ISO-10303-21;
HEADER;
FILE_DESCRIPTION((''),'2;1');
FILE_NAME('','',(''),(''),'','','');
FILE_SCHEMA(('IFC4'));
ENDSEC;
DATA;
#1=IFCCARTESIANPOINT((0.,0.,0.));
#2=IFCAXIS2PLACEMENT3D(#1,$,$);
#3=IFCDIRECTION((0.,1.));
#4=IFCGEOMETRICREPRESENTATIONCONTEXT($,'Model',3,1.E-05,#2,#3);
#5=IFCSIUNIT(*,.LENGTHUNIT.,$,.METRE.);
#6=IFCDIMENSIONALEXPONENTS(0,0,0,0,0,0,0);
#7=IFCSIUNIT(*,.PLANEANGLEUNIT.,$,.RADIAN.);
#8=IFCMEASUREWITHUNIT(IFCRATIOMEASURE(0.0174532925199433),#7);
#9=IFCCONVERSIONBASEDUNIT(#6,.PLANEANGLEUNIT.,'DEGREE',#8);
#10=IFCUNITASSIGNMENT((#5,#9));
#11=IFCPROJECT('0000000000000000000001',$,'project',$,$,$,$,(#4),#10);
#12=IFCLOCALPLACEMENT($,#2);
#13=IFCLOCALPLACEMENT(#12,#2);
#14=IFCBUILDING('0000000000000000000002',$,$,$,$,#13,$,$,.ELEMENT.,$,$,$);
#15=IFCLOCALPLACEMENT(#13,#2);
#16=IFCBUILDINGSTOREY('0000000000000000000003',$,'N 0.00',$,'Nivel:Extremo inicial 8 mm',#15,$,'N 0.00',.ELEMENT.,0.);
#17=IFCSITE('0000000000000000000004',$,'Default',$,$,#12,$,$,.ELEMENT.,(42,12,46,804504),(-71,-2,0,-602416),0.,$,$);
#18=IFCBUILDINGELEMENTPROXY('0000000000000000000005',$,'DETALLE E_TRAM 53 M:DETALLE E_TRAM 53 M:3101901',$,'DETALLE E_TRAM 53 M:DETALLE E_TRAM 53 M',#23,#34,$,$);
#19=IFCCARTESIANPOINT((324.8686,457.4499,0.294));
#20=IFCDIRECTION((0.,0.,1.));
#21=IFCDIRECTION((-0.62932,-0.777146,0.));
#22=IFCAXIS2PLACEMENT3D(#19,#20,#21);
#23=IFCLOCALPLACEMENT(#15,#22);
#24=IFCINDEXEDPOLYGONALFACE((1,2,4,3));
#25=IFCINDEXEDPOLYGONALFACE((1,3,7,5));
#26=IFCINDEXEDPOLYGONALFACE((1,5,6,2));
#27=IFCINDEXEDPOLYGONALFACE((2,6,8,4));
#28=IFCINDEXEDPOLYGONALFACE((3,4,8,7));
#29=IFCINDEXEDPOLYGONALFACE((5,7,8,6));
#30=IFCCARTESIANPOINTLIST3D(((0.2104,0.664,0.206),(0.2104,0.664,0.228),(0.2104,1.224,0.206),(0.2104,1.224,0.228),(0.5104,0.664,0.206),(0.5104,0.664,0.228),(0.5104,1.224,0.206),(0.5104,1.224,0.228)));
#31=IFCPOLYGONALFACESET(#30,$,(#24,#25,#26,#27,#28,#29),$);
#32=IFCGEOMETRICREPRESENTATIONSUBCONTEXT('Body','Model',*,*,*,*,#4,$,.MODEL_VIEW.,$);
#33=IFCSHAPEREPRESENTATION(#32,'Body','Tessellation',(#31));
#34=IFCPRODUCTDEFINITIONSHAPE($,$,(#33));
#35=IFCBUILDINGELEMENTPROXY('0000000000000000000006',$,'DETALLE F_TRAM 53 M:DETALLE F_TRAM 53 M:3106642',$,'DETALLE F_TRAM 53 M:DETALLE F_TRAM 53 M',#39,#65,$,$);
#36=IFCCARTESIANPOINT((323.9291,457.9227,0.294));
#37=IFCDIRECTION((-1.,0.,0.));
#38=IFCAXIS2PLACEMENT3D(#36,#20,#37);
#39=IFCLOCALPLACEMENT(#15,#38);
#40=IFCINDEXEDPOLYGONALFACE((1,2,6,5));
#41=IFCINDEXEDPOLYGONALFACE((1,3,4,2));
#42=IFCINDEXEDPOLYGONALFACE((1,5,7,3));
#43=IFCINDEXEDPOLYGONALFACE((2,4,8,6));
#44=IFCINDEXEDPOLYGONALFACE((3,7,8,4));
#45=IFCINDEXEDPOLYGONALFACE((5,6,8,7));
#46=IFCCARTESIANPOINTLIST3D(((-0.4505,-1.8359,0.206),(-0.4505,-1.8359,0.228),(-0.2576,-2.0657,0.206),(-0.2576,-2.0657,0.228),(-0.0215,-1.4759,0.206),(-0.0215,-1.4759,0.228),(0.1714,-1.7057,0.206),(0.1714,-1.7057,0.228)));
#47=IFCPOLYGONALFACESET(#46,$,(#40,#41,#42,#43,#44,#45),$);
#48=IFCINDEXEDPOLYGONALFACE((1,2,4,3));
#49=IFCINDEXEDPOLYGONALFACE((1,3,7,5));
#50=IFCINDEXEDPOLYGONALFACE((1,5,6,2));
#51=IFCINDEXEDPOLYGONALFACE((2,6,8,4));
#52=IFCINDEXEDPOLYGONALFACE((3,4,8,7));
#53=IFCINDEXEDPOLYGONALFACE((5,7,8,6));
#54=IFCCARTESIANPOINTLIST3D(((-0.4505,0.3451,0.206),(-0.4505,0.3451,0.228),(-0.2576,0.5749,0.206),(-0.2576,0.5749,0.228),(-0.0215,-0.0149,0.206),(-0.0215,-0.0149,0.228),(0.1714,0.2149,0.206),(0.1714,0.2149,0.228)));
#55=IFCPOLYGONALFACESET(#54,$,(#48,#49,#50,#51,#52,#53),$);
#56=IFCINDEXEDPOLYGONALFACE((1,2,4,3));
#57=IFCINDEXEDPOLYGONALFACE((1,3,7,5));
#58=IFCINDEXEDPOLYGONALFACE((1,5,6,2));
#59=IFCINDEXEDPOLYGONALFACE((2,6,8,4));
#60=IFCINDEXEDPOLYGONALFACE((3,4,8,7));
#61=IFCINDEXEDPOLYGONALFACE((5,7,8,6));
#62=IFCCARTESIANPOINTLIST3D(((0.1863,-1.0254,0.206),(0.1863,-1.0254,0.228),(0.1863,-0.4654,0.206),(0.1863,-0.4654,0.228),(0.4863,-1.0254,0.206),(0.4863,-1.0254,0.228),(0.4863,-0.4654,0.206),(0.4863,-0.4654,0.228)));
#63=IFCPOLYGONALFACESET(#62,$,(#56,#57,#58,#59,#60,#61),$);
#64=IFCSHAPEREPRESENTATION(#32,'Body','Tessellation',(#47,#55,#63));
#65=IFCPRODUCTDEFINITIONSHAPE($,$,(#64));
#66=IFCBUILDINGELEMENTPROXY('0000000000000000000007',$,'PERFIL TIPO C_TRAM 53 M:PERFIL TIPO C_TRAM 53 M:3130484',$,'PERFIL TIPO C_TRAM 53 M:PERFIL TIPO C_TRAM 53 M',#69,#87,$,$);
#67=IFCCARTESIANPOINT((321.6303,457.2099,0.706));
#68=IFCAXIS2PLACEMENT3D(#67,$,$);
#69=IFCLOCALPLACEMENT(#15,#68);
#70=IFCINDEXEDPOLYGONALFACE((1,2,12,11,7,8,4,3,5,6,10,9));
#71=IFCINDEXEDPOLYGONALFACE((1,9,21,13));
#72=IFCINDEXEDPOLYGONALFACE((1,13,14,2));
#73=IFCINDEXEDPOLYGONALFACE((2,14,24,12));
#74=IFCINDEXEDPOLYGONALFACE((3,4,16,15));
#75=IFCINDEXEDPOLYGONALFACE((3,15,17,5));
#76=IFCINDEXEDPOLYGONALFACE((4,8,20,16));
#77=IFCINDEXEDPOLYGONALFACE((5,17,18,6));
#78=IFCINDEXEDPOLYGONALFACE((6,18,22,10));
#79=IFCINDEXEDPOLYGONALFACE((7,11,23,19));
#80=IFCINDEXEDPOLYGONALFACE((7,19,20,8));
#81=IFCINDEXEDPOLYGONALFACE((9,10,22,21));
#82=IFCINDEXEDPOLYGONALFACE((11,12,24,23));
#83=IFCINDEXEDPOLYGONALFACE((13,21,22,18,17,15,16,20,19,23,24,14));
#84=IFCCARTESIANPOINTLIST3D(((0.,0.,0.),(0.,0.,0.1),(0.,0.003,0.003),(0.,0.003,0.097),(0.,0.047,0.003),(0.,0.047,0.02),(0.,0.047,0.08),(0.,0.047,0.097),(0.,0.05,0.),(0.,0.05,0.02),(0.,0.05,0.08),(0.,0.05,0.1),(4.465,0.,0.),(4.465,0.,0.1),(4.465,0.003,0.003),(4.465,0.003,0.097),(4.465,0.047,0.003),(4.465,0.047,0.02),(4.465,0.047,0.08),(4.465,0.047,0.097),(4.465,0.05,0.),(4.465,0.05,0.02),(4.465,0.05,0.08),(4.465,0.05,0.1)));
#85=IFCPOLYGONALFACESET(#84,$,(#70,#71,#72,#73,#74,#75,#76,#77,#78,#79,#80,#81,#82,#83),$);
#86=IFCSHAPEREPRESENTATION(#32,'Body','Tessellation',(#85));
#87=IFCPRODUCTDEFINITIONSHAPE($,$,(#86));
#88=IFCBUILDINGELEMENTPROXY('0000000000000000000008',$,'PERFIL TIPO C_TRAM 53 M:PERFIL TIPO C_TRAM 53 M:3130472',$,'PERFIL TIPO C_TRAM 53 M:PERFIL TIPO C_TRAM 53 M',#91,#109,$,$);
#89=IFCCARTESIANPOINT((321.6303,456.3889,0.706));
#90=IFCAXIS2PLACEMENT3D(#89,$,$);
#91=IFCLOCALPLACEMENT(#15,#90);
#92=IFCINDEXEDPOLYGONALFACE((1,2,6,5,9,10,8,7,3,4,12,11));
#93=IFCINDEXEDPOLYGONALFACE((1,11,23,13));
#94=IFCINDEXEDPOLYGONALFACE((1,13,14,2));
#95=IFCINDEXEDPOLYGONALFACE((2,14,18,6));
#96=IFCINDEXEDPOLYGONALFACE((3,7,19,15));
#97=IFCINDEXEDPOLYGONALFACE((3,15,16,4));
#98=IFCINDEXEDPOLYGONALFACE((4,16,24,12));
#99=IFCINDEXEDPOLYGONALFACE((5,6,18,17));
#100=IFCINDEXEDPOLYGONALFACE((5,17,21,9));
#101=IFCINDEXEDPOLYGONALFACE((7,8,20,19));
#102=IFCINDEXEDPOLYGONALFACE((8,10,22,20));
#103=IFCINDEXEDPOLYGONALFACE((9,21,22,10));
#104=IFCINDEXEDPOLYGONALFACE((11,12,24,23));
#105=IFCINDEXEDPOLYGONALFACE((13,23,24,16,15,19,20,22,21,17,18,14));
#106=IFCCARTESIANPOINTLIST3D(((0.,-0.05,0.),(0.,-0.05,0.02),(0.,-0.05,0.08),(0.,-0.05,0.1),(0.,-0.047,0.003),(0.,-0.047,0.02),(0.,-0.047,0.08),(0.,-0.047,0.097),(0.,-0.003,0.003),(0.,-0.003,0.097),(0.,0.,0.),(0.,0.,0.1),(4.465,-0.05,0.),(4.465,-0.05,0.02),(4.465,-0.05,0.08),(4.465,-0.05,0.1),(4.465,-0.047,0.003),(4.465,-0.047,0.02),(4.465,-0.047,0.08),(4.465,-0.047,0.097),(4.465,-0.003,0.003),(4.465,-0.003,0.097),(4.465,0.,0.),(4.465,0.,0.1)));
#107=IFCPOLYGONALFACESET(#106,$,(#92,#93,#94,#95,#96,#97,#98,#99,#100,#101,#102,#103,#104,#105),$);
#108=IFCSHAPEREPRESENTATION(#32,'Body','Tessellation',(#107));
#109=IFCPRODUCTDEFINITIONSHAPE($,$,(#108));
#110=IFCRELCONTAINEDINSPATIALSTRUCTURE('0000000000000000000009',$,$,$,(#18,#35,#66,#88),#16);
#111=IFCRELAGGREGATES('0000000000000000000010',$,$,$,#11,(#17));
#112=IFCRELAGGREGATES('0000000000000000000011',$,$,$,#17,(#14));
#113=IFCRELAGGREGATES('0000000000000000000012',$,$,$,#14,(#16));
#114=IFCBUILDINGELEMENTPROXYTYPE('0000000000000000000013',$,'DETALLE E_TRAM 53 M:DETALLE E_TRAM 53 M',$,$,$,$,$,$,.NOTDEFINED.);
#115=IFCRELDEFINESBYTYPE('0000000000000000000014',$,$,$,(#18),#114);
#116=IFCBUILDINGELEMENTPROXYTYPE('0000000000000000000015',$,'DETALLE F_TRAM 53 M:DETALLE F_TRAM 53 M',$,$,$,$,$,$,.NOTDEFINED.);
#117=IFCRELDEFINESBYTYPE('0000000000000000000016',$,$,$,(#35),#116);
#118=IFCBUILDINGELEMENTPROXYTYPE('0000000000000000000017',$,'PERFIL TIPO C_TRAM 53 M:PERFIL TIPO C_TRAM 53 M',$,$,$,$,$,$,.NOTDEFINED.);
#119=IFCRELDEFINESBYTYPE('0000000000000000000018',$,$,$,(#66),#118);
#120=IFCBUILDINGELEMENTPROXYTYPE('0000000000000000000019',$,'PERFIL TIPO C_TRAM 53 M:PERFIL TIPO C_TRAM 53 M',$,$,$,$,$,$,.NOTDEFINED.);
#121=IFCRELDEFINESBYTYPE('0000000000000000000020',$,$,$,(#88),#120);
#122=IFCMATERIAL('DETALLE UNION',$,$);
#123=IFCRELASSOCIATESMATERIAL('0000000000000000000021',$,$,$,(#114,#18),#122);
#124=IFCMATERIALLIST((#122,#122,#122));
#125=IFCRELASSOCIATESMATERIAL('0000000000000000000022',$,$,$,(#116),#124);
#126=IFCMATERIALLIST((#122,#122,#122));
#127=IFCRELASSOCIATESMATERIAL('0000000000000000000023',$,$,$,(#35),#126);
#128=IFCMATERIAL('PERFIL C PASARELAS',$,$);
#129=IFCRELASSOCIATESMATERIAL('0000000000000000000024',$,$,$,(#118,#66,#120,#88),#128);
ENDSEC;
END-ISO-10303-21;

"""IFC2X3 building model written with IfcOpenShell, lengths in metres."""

from ifc_helpers import new_model, entity, si_unit, converted_unit, direction, frame, frame_2d, origin, place, context, subcontext, project, spatial, polyline, rectangle, outline, extrude, source, transform, mapped, material, material_list, type_object, type_shapes, element, save


model = new_model("IFC2X3")

# Units and contexts
model_context = context("Model", 3, precision=1e-05, world=origin(), true_north=direction((0.0, 1.0)))
body_context = subcontext(model_context, "Body", "Model", "MODEL_VIEW")
ifc_project = project(units=[si_unit("LENGTHUNIT", "METRE"), converted_unit("PLANEANGLEUNIT", "DEGREE", entity("IfcRatioMeasure", 0.0174532925199433), si_unit("PLANEANGLEUNIT", "RADIAN"), dimensions=[0, 0, 0, 0, 0, 0, 0])], contexts=[model_context])

# Site, building, storey
site_placement = place(None, origin())
site = spatial("IfcSite", under=ifc_project, at=site_placement, Name="Default", CompositionType="ELEMENT", RefLatitude=(42, 12, 46, 804504), RefLongitude=(-71, -2, 0, -602416), RefElevation=0.0)
building_placement = place(site_placement, origin())
building = spatial("IfcBuilding", under=site, at=building_placement, CompositionType="ELEMENT")
storey_placement = place(building_placement, origin())
storey = spatial("IfcBuildingStorey", under=building, at=storey_placement, Name="N 0.00", ObjectType="Nivel:Extremo inicial 8 mm", LongName="N 0.00", CompositionType="ELEMENT", Elevation=0.0)

# Building element proxies
ifc_material_1 = material(Name="DETALLE UNION")
building_element_proxy_type_1 = type_object("IfcBuildingElementProxyType", Name="DETALLE E_TRAM 53 M:DETALLE E_TRAM 53 M", PredefinedType="NOTDEFINED", material=ifc_material_1)
shared_shape_1 = source(origin(), body_context, "Body", "SweptSolid", [
    extrude(rectangle(XDim=0.56, YDim=0.3, at=frame_2d((0.0, 0.0), x_axis=(1.0, 0.0))), frame((0.3604, 0.944, 0.206), z_axis=(0.0, 0.0, 1.0), x_axis=(0.0, 1.0, 0.0)), (0.0, 0.0, 1.0), 0.022),
])
type_shapes(building_element_proxy_type_1, [shared_shape_1])
proxy_1_placement = place(storey_placement, frame((324.8686, 457.4499, 0.294), z_axis=(0.0, 0.0, 1.0), x_axis=(-0.62932, -0.777146, 0.0)))
element("IfcBuildingElementProxy", 1, at=proxy_1_placement, inside=storey, type_object=building_element_proxy_type_1, material=ifc_material_1, Name="DETALLE E_TRAM 53 M:DETALLE E_TRAM 53 M:3101901", ObjectType="DETALLE E_TRAM 53 M:DETALLE E_TRAM 53 M", context=body_context, shape_type="MappedRepresentation", body=[
    mapped(shared_shape_1, transform((0.0, 0.0, 0.0), scale=1.0)),
])
ifc_material_list_1 = material_list([ifc_material_1, ifc_material_1, ifc_material_1])
ifc_material_list_2 = material_list([ifc_material_1, ifc_material_1, ifc_material_1])
building_element_proxy_type_2 = type_object("IfcBuildingElementProxyType", Name="DETALLE F_TRAM 53 M:DETALLE F_TRAM 53 M", PredefinedType="NOTDEFINED", material=ifc_material_list_2)
shared_shape_2 = source(origin(), body_context, "Body", "SweptSolid", [
    extrude(rectangle(XDim=0.56, YDim=0.3, at=frame_2d((0.0, 0.0), x_axis=(1.0, 0.0))), frame((-0.1396, -1.7708, 0.206), z_axis=(0.0, 0.0, 1.0), x_axis=(0.766044, 0.642788, 0.0)), (0.0, 0.0, 1.0), 0.022),
    extrude(rectangle(XDim=0.3, YDim=0.56, at=frame_2d((0.0, 0.0), x_axis=(1.0, 0.0))), frame((-0.1396, 0.28, 0.206), z_axis=(0.0, 0.0, 1.0), x_axis=(-0.642788, -0.766044, 0.0)), (0.0, 0.0, 1.0), 0.022),
    extrude(rectangle(XDim=0.3, YDim=0.56, at=frame_2d((0.0, 0.0), x_axis=(1.0, 0.0))), frame((0.3363, -0.7454, 0.206), z_axis=(0.0, 0.0, 1.0), x_axis=(-1.0, 0.0, 0.0)), (0.0, 0.0, 1.0), 0.022),
])
type_shapes(building_element_proxy_type_2, [shared_shape_2])
proxy_2_placement = place(storey_placement, frame((323.9291, 457.9227, 0.294), z_axis=(0.0, 0.0, 1.0), x_axis=(-1.0, 0.0, 0.0)))
element("IfcBuildingElementProxy", 2, at=proxy_2_placement, inside=storey, type_object=building_element_proxy_type_2, material=ifc_material_list_1, Name="DETALLE F_TRAM 53 M:DETALLE F_TRAM 53 M:3106642", ObjectType="DETALLE F_TRAM 53 M:DETALLE F_TRAM 53 M", context=body_context, shape_type="MappedRepresentation", body=[
    mapped(shared_shape_2, transform((0.0, 0.0, 0.0), scale=1.0)),
])
ifc_material_2 = material(Name="PERFIL C PASARELAS")
building_element_proxy_type_3 = type_object("IfcBuildingElementProxyType", Name="PERFIL TIPO C_TRAM 53 M:PERFIL TIPO C_TRAM 53 M", PredefinedType="NOTDEFINED", material=ifc_material_2)
shared_shape_3 = source(origin(), body_context, "Body", "SweptSolid", [
    extrude(outline(polyline([(-0.0172, 0.03), (-0.0142, 0.03), (-0.0142, 0.047), (0.0298, 0.047), (0.0298, -0.047), (-0.0142, -0.047), (-0.0142, -0.03), (-0.0172, -0.03), (-0.0172, -0.05), (0.0328, -0.05), (0.0328, 0.05), (-0.0172, 0.05), (-0.0172, 0.03)])), frame((0.0, 0.0328, 0.05), z_axis=(1.0, 0.0, 0.0), x_axis=(0.0, -1.0, 0.0)), (0.0, 0.0, 1.0), 4.465),
])
type_shapes(building_element_proxy_type_3, [shared_shape_3])
proxy_3_placement = place(storey_placement, frame((321.6303, 457.2099, 0.706)))
element("IfcBuildingElementProxy", 3, at=proxy_3_placement, inside=storey, type_object=building_element_proxy_type_3, material=ifc_material_2, Name="PERFIL TIPO C_TRAM 53 M:PERFIL TIPO C_TRAM 53 M:3130484", ObjectType="PERFIL TIPO C_TRAM 53 M:PERFIL TIPO C_TRAM 53 M", context=body_context, shape_type="MappedRepresentation", body=[
    mapped(shared_shape_3, transform((0.0, 0.0, 0.0), scale=1.0)),
])
building_element_proxy_type_4 = type_object("IfcBuildingElementProxyType", Name="PERFIL TIPO C_TRAM 53 M:PERFIL TIPO C_TRAM 53 M", PredefinedType="NOTDEFINED", material=ifc_material_2)
shared_shape_4 = source(origin(), body_context, "Body", "SweptSolid", [
    extrude(outline(polyline([(0.03, -0.0172), (0.05, -0.0172), (0.05, 0.0328), (-0.05, 0.0328), (-0.05, -0.0172), (-0.03, -0.0172), (-0.03, -0.0142), (-0.047, -0.0142), (-0.047, 0.0298), (0.047, 0.0298), (0.047, -0.0142), (0.03, -0.0142), (0.03, -0.0172)])), frame((0.0, -0.0328, 0.05), z_axis=(1.0, 0.0, 0.0), x_axis=(0.0, 0.0, -1.0)), (0.0, 0.0, 1.0), 4.465),
])
type_shapes(building_element_proxy_type_4, [shared_shape_4])
proxy_4_placement = place(storey_placement, frame((321.6303, 456.3889, 0.706)))
element("IfcBuildingElementProxy", 4, at=proxy_4_placement, inside=storey, type_object=building_element_proxy_type_4, material=ifc_material_2, Name="PERFIL TIPO C_TRAM 53 M:PERFIL TIPO C_TRAM 53 M:3130472", ObjectType="PERFIL TIPO C_TRAM 53 M:PERFIL TIPO C_TRAM 53 M", context=body_context, shape_type="MappedRepresentation", body=[
    mapped(shared_shape_4, transform((0.0, 0.0, 0.0), scale=1.0)),
])

save(model, "model.ifc")
